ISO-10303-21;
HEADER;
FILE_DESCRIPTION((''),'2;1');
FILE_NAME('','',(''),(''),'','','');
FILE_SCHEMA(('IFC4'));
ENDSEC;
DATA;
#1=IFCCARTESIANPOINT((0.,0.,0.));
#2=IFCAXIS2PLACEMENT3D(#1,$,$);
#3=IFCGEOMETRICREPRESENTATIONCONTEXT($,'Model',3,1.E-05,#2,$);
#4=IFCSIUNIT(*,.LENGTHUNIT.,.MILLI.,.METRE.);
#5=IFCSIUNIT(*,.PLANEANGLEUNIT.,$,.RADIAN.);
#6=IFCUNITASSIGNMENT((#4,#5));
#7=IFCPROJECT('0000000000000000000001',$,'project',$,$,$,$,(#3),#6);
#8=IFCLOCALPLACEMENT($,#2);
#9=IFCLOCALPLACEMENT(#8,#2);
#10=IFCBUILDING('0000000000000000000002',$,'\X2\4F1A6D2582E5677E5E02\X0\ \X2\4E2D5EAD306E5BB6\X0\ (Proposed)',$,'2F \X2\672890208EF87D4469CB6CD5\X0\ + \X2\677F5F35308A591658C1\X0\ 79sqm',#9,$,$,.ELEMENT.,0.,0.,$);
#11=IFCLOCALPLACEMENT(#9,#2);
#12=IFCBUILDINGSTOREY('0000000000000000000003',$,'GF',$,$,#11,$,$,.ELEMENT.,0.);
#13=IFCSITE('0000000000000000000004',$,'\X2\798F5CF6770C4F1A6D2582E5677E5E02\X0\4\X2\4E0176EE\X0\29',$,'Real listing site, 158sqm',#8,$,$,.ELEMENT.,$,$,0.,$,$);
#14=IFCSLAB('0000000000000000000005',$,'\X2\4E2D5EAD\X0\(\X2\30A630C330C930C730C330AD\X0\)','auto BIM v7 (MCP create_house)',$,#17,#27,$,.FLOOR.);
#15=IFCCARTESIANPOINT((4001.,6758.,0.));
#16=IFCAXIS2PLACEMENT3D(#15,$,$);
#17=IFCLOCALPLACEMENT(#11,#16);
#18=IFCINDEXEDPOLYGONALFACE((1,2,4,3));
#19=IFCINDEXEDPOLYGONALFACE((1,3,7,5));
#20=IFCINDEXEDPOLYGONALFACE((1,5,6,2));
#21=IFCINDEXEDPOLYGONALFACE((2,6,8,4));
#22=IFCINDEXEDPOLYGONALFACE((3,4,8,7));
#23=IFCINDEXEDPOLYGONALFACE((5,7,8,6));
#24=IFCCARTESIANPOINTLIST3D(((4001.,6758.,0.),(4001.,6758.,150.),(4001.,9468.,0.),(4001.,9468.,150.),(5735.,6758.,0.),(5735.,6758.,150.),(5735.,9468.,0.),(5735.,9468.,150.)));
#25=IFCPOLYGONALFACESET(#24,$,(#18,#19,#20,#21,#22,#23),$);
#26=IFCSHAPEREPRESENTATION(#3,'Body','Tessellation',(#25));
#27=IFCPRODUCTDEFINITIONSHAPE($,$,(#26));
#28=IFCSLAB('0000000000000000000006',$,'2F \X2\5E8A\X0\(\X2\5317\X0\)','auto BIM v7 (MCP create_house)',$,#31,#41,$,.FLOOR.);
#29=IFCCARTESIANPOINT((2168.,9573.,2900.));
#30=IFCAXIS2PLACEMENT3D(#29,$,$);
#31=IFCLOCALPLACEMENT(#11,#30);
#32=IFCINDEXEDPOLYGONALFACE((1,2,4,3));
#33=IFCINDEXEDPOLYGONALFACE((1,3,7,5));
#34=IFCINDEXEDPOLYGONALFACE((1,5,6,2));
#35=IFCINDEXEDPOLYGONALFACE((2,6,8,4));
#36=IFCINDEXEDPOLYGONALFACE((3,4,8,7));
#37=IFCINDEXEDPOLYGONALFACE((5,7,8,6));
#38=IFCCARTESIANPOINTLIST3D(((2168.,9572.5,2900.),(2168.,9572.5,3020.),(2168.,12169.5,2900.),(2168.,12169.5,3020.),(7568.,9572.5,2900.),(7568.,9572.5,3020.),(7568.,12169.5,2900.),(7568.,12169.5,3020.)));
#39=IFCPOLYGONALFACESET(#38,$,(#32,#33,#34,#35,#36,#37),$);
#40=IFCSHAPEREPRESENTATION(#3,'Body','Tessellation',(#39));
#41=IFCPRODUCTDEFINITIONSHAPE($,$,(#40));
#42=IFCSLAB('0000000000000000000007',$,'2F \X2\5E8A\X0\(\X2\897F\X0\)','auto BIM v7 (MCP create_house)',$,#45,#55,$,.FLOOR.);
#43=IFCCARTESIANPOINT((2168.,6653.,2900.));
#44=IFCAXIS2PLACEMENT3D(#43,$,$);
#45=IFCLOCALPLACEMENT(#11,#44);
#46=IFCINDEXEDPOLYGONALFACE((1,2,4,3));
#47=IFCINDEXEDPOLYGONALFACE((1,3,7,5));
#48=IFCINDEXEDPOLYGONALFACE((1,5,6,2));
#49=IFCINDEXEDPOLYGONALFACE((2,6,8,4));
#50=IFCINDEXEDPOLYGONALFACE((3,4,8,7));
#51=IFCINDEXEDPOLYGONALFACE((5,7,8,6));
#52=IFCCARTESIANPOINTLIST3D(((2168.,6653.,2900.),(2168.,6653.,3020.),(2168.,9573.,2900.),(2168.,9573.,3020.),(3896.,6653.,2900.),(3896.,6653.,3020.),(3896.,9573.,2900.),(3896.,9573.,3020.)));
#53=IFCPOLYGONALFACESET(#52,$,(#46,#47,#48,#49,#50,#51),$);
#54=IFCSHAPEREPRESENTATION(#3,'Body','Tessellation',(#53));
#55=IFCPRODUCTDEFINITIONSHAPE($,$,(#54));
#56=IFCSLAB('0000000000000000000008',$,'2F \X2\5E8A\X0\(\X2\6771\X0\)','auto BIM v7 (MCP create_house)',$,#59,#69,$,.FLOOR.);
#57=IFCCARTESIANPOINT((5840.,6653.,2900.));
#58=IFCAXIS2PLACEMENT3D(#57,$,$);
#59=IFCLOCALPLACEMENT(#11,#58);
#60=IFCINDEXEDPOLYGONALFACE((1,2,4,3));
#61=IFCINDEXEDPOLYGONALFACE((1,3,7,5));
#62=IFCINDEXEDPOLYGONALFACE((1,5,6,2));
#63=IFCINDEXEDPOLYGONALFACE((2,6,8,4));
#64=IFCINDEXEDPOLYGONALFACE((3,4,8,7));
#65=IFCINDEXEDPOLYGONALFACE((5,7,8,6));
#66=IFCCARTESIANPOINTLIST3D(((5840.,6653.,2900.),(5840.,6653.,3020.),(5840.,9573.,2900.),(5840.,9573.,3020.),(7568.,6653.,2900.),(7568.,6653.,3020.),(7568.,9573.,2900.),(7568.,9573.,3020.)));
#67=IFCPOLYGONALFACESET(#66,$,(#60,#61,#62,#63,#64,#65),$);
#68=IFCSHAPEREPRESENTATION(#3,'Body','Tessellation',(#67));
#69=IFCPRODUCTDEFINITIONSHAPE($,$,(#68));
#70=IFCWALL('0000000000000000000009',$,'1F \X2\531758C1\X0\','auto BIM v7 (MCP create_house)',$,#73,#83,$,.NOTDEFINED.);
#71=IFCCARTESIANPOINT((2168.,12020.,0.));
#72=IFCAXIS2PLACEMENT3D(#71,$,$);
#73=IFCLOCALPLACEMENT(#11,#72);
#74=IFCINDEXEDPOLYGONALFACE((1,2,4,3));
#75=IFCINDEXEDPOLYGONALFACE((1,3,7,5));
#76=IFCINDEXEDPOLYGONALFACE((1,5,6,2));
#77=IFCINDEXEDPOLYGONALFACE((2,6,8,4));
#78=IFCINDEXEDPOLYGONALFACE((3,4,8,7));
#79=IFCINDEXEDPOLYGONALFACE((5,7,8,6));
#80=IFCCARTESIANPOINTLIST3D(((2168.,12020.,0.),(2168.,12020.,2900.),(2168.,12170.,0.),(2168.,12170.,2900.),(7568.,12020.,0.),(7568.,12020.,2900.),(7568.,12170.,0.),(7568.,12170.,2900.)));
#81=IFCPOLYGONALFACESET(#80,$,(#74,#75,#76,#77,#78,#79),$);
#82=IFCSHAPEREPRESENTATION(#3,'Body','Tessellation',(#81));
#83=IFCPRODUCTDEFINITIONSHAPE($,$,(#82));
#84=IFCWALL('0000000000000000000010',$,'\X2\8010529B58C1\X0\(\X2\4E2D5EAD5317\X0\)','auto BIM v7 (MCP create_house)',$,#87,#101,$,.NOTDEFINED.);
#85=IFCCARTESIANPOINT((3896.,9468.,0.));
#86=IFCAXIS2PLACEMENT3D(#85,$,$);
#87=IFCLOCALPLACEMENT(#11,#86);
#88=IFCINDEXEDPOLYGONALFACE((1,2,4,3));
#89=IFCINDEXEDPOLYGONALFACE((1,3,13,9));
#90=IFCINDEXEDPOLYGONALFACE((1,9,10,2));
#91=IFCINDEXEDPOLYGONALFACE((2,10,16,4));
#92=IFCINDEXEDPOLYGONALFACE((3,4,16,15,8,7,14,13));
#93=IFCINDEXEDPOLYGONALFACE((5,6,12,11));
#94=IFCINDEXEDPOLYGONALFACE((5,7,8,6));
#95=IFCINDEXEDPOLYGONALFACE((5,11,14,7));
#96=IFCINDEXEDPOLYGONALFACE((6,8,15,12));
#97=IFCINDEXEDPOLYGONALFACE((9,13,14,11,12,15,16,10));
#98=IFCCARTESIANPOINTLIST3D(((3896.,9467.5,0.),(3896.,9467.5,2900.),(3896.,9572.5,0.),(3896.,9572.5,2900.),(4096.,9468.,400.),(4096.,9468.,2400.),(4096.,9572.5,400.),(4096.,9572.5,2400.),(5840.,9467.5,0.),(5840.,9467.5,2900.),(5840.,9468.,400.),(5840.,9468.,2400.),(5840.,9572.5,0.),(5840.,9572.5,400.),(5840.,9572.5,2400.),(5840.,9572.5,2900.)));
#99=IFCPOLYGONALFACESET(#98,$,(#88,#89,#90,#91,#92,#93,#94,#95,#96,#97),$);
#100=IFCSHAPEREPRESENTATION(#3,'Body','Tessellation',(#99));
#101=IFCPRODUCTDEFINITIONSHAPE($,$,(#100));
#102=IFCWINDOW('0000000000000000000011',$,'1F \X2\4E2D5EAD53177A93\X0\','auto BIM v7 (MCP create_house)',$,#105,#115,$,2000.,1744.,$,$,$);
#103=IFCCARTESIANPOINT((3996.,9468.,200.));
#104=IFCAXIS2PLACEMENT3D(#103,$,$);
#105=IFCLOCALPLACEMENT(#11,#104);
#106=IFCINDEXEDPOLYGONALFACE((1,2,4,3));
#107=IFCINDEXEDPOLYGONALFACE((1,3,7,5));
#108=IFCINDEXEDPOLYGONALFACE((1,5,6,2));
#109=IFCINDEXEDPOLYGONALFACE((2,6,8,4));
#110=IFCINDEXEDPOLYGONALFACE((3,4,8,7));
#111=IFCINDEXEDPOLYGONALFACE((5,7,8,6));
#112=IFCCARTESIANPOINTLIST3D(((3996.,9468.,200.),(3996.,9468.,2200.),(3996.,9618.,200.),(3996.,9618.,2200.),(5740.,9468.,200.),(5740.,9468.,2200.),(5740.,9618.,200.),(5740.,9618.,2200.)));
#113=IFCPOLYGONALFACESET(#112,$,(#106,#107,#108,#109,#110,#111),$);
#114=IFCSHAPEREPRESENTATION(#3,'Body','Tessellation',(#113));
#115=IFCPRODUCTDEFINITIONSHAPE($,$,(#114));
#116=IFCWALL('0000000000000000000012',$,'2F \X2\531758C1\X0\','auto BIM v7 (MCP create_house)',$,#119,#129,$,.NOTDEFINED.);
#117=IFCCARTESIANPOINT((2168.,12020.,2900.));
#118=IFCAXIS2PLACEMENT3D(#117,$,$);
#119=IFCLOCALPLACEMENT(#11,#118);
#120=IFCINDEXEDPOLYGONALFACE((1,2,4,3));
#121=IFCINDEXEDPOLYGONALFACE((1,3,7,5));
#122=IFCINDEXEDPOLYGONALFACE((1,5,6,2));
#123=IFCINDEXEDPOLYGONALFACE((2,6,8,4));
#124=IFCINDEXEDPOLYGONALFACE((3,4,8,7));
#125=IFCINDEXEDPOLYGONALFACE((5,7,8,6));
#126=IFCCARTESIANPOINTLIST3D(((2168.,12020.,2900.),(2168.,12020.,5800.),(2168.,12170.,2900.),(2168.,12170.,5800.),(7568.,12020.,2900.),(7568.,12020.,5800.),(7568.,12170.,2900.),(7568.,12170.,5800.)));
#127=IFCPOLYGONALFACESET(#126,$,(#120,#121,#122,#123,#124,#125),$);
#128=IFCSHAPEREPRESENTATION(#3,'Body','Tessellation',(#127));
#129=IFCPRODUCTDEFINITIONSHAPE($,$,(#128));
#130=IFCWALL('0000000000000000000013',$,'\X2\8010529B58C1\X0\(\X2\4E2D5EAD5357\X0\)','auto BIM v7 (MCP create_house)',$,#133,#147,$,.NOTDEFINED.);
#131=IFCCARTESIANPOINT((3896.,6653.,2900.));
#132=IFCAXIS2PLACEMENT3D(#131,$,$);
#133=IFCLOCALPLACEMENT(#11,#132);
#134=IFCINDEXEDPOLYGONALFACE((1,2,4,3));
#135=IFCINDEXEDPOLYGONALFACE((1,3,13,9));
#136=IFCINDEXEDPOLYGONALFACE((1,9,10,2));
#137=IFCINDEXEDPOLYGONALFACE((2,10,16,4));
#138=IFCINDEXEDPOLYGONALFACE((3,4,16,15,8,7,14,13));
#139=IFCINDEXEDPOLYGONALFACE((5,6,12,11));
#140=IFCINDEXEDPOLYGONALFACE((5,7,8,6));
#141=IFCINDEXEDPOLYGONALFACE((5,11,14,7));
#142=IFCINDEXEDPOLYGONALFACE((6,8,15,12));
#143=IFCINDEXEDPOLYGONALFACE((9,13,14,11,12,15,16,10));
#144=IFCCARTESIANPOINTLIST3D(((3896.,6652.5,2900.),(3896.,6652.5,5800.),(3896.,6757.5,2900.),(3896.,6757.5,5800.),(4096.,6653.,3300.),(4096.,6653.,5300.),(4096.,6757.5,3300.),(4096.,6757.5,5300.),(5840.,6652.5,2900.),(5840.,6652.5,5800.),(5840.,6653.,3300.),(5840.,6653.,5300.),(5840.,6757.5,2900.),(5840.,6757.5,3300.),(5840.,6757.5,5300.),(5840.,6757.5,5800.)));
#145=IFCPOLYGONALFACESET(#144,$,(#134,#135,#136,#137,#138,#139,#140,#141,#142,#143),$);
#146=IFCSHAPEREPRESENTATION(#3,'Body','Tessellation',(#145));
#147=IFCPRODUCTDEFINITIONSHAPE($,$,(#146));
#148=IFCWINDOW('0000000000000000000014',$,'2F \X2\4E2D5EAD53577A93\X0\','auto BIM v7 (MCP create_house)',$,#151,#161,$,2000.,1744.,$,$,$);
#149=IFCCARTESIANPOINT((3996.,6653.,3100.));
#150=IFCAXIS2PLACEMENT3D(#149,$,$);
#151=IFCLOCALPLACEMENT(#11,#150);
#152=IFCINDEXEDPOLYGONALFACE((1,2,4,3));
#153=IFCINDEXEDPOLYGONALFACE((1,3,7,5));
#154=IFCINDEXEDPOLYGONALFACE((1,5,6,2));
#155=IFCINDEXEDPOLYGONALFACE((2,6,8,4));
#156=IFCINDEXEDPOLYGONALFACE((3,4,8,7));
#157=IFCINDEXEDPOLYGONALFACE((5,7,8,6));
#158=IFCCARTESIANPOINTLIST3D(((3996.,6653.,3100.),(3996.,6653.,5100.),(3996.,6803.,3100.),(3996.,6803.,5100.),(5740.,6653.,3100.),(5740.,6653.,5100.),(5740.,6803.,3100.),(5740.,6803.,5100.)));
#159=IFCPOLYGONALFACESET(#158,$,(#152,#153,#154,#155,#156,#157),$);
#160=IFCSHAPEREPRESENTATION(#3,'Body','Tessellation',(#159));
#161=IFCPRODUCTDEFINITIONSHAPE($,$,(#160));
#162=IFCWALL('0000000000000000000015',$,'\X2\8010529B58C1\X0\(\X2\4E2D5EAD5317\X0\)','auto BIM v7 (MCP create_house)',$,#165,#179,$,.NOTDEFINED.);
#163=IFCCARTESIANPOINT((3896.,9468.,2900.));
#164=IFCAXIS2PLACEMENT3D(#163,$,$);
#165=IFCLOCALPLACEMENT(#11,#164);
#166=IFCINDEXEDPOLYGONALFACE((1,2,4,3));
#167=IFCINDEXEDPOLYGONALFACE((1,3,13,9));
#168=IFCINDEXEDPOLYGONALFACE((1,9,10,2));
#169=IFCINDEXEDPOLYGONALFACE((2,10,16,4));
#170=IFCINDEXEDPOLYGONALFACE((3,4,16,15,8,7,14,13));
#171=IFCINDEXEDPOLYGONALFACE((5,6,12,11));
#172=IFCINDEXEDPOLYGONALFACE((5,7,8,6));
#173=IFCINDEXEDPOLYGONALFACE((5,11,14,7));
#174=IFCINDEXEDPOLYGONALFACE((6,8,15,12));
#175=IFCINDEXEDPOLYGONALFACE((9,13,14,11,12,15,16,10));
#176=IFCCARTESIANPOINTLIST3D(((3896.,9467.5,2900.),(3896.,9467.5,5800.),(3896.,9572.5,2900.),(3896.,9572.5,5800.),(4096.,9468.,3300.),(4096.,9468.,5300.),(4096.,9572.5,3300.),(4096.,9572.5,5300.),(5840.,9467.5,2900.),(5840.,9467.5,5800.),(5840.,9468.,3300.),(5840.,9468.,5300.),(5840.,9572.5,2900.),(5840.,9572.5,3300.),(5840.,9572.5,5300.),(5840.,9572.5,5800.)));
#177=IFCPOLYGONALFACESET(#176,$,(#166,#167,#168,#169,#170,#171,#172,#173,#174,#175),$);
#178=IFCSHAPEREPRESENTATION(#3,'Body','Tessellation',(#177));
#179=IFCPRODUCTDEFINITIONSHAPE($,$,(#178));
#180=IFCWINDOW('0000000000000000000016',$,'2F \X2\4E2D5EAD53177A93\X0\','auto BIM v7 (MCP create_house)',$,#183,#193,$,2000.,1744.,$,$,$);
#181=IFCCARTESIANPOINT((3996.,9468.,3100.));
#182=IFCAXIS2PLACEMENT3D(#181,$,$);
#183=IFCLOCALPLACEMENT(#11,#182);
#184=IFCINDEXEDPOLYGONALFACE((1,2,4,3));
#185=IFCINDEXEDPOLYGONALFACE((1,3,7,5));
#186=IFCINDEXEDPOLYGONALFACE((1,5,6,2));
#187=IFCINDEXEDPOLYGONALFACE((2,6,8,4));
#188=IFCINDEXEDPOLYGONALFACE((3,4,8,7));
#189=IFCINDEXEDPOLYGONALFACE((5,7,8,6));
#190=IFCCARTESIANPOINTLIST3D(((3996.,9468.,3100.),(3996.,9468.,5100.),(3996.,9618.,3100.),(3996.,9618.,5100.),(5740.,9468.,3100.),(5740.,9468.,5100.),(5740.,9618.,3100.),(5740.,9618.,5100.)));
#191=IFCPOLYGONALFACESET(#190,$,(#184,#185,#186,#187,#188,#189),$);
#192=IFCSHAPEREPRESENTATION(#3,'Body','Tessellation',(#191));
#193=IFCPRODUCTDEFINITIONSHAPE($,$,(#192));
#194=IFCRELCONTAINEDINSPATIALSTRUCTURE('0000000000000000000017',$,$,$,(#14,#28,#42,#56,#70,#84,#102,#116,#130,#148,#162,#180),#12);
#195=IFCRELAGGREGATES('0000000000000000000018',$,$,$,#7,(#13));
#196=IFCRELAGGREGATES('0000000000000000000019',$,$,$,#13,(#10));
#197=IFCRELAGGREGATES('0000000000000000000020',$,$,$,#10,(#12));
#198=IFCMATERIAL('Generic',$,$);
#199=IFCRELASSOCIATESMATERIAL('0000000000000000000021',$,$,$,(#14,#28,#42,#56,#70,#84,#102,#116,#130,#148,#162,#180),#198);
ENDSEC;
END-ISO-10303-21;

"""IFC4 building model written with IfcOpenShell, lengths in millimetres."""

from ifc_helpers import new_model, si_unit, frame, frame_2d, origin, place, context, project, spatial, rectangle, extrude, material, element, fill, save


model = new_model("IFC4")

# Units and contexts
model_context = context("Model", 3, precision=1e-05, world=origin())
ifc_project = project(units=[si_unit("LENGTHUNIT", "METRE", prefix="MILLI"), si_unit("PLANEANGLEUNIT", "RADIAN")], contexts=[model_context])

# Site, building, storey
site_placement = place(None, origin())
site = spatial("IfcSite", under=ifc_project, at=site_placement, Name="福島県会津若松市4丁目29", ObjectType="Real listing site, 158sqm", CompositionType="ELEMENT", RefElevation=0.0)
building_placement = place(site_placement, origin())
building = spatial("IfcBuilding", under=site, at=building_placement, Name="会津若松市 中庭の家 (Proposed)", ObjectType="2F 木造軸組構法 + 板張り外壁 79sqm", CompositionType="ELEMENT", ElevationOfRefHeight=0.0, ElevationOfTerrain=0.0)
storey_placement = place(building_placement, origin())
storey = spatial("IfcBuildingStorey", under=building, at=storey_placement, Name="GF", CompositionType="ELEMENT", Elevation=0.0)

# Slabs
ifc_material = material(Name="Generic")
slab_1_placement = place(storey_placement, frame((4001.0, 6758.0, 0.0)))
element("IfcSlab", 1, at=slab_1_placement, inside=storey, material=ifc_material, Name="中庭(ウッドデッキ)", Description="auto BIM v7 (MCP create_house)", PredefinedType="FLOOR", context=model_context, shape_type="SweptSolid", body=[
    extrude(rectangle(XDim=1734.0, YDim=2710.0, at=frame_2d((867.0, 1355.0))), frame((4001.0, 6758.0, 0.0)), (0.0, 0.0, 1.0), 150.0),
])
slab_2_placement = place(storey_placement, frame((2168.0, 9573.0, 2900.0)))
element("IfcSlab", 2, at=slab_2_placement, inside=storey, material=ifc_material, Name="2F 床(北)", Description="auto BIM v7 (MCP create_house)", PredefinedType="FLOOR", context=model_context, shape_type="SweptSolid", body=[
    extrude(rectangle(XDim=5400.0, YDim=2597.0, at=frame_2d((2700.0, 1298.0))), frame((2168.0, 9573.0, 2900.0)), (0.0, 0.0, 1.0), 120.0),
])
slab_3_placement = place(storey_placement, frame((2168.0, 6653.0, 2900.0)))
element("IfcSlab", 3, at=slab_3_placement, inside=storey, material=ifc_material, Name="2F 床(西)", Description="auto BIM v7 (MCP create_house)", PredefinedType="FLOOR", context=model_context, shape_type="SweptSolid", body=[
    extrude(rectangle(XDim=1728.0, YDim=2920.0, at=frame_2d((864.0, 1460.0))), frame((2168.0, 6653.0, 2900.0)), (0.0, 0.0, 1.0), 120.0),
])
slab_4_placement = place(storey_placement, frame((5840.0, 6653.0, 2900.0)))
element("IfcSlab", 4, at=slab_4_placement, inside=storey, material=ifc_material, Name="2F 床(東)", Description="auto BIM v7 (MCP create_house)", PredefinedType="FLOOR", context=model_context, shape_type="SweptSolid", body=[
    extrude(rectangle(XDim=1728.0, YDim=2920.0, at=frame_2d((864.0, 1460.0))), frame((5840.0, 6653.0, 2900.0)), (0.0, 0.0, 1.0), 120.0),
])

# Wall
wall_1_placement = place(storey_placement, frame((2168.0, 12020.0, 0.0)))
element("IfcWall", 5, at=wall_1_placement, inside=storey, material=ifc_material, Name="1F 北壁", Description="auto BIM v7 (MCP create_house)", PredefinedType="NOTDEFINED", context=model_context, shape_type="SweptSolid", body=[
    extrude(rectangle(XDim=5400.0, YDim=150.0, at=frame_2d((2700.0, 75.0))), frame((2168.0, 12020.0, 0.0)), (0.0, 0.0, 1.0), 2900.0),
])

# Wall, opening, window
wall_2_placement = place(storey_placement, frame((3896.0, 9468.0, 0.0)))
wall_2 = element("IfcWall", 6, at=wall_2_placement, inside=storey, material=ifc_material, Name="耐力壁(中庭北)", Description="auto BIM v7 (MCP create_house)", PredefinedType="NOTDEFINED", context=model_context, shape_type="SweptSolid", body=[
    extrude(rectangle(XDim=1944.0, YDim=105.0, at=frame_2d((972.0, 52.0))), frame((3896.0, 9468.0, 0.0)), (0.0, 0.0, 1.0), 2900.0),
])
opening_1_placement = place(storey_placement, frame((3996.0, 9468.0, 200.0)))
opening_1 = element("IfcOpeningElement", 7, at=opening_1_placement, cuts=wall_2, PredefinedType="NOTDEFINED", context=model_context, shape_type="SweptSolid", body=[
    extrude(rectangle(XDim=1744.0, YDim=150.0, at=frame_2d((872.0, 75.0))), frame((3996.0, 9468.0, 200.0)), (0.0, 0.0, 1.0), 2000.0),
])
window_1_placement = place(storey_placement, frame((3996.0, 9468.0, 200.0)))
window_1 = element("IfcWindow", 8, at=window_1_placement, inside=storey, material=ifc_material, Name="1F 中庭北窓", Description="auto BIM v7 (MCP create_house)", OverallHeight=2000.0, OverallWidth=1744.0, context=model_context, shape_type="SweptSolid", body=[
    extrude(rectangle(XDim=1744.0, YDim=150.0, at=frame_2d((872.0, 75.0))), frame((3996.0, 9468.0, 200.0)), (0.0, 0.0, 1.0), 2000.0),
])
fill(opening_1, window_1)

# Wall
wall_3_placement = place(storey_placement, frame((2168.0, 12020.0, 2900.0)))
element("IfcWall", 9, at=wall_3_placement, inside=storey, material=ifc_material, Name="2F 北壁", Description="auto BIM v7 (MCP create_house)", PredefinedType="NOTDEFINED", context=model_context, shape_type="SweptSolid", body=[
    extrude(rectangle(XDim=5400.0, YDim=150.0, at=frame_2d((2700.0, 75.0))), frame((2168.0, 12020.0, 2900.0)), (0.0, 0.0, 1.0), 2900.0),
])

# Walls, openings, windows
wall_4_placement = place(storey_placement, frame((3896.0, 6653.0, 2900.0)))
wall_4 = element("IfcWall", 10, at=wall_4_placement, inside=storey, material=ifc_material, Name="耐力壁(中庭南)", Description="auto BIM v7 (MCP create_house)", PredefinedType="NOTDEFINED", context=model_context, shape_type="SweptSolid", body=[
    extrude(rectangle(XDim=1944.0, YDim=105.0, at=frame_2d((972.0, 52.0))), frame((3896.0, 6653.0, 2900.0)), (0.0, 0.0, 1.0), 2900.0),
])
opening_2_placement = place(storey_placement, frame((3996.0, 6653.0, 3100.0)))
opening_2 = element("IfcOpeningElement", 11, at=opening_2_placement, cuts=wall_4, PredefinedType="NOTDEFINED", context=model_context, shape_type="SweptSolid", body=[
    extrude(rectangle(XDim=1744.0, YDim=150.0, at=frame_2d((872.0, 75.0))), frame((3996.0, 6653.0, 3100.0)), (0.0, 0.0, 1.0), 2000.0),
])
window_2_placement = place(storey_placement, frame((3996.0, 6653.0, 3100.0)))
window_2 = element("IfcWindow", 12, at=window_2_placement, inside=storey, material=ifc_material, Name="2F 中庭南窓", Description="auto BIM v7 (MCP create_house)", OverallHeight=2000.0, OverallWidth=1744.0, context=model_context, shape_type="SweptSolid", body=[
    extrude(rectangle(XDim=1744.0, YDim=150.0, at=frame_2d((872.0, 75.0))), frame((3996.0, 6653.0, 3100.0)), (0.0, 0.0, 1.0), 2000.0),
])
fill(opening_2, window_2)
wall_5_placement = place(storey_placement, frame((3896.0, 9468.0, 2900.0)))
wall_5 = element("IfcWall", 13, at=wall_5_placement, inside=storey, material=ifc_material, Name="耐力壁(中庭北)", Description="auto BIM v7 (MCP create_house)", PredefinedType="NOTDEFINED", context=model_context, shape_type="SweptSolid", body=[
    extrude(rectangle(XDim=1944.0, YDim=105.0, at=frame_2d((972.0, 52.0))), frame((3896.0, 9468.0, 2900.0)), (0.0, 0.0, 1.0), 2900.0),
])
opening_3_placement = place(storey_placement, frame((3996.0, 9468.0, 3100.0)))
opening_3 = element("IfcOpeningElement", 14, at=opening_3_placement, cuts=wall_5, PredefinedType="NOTDEFINED", context=model_context, shape_type="SweptSolid", body=[
    extrude(rectangle(XDim=1744.0, YDim=150.0, at=frame_2d((872.0, 75.0))), frame((3996.0, 9468.0, 3100.0)), (0.0, 0.0, 1.0), 2000.0),
])
window_3_placement = place(storey_placement, frame((3996.0, 9468.0, 3100.0)))
window_3 = element("IfcWindow", 15, at=window_3_placement, inside=storey, material=ifc_material, Name="2F 中庭北窓", Description="auto BIM v7 (MCP create_house)", OverallHeight=2000.0, OverallWidth=1744.0, context=model_context, shape_type="SweptSolid", body=[
    extrude(rectangle(XDim=1744.0, YDim=150.0, at=frame_2d((872.0, 75.0))), frame((3996.0, 9468.0, 3100.0)), (0.0, 0.0, 1.0), 2000.0),
])
fill(opening_3, window_3)

save(model, "model.ifc")
